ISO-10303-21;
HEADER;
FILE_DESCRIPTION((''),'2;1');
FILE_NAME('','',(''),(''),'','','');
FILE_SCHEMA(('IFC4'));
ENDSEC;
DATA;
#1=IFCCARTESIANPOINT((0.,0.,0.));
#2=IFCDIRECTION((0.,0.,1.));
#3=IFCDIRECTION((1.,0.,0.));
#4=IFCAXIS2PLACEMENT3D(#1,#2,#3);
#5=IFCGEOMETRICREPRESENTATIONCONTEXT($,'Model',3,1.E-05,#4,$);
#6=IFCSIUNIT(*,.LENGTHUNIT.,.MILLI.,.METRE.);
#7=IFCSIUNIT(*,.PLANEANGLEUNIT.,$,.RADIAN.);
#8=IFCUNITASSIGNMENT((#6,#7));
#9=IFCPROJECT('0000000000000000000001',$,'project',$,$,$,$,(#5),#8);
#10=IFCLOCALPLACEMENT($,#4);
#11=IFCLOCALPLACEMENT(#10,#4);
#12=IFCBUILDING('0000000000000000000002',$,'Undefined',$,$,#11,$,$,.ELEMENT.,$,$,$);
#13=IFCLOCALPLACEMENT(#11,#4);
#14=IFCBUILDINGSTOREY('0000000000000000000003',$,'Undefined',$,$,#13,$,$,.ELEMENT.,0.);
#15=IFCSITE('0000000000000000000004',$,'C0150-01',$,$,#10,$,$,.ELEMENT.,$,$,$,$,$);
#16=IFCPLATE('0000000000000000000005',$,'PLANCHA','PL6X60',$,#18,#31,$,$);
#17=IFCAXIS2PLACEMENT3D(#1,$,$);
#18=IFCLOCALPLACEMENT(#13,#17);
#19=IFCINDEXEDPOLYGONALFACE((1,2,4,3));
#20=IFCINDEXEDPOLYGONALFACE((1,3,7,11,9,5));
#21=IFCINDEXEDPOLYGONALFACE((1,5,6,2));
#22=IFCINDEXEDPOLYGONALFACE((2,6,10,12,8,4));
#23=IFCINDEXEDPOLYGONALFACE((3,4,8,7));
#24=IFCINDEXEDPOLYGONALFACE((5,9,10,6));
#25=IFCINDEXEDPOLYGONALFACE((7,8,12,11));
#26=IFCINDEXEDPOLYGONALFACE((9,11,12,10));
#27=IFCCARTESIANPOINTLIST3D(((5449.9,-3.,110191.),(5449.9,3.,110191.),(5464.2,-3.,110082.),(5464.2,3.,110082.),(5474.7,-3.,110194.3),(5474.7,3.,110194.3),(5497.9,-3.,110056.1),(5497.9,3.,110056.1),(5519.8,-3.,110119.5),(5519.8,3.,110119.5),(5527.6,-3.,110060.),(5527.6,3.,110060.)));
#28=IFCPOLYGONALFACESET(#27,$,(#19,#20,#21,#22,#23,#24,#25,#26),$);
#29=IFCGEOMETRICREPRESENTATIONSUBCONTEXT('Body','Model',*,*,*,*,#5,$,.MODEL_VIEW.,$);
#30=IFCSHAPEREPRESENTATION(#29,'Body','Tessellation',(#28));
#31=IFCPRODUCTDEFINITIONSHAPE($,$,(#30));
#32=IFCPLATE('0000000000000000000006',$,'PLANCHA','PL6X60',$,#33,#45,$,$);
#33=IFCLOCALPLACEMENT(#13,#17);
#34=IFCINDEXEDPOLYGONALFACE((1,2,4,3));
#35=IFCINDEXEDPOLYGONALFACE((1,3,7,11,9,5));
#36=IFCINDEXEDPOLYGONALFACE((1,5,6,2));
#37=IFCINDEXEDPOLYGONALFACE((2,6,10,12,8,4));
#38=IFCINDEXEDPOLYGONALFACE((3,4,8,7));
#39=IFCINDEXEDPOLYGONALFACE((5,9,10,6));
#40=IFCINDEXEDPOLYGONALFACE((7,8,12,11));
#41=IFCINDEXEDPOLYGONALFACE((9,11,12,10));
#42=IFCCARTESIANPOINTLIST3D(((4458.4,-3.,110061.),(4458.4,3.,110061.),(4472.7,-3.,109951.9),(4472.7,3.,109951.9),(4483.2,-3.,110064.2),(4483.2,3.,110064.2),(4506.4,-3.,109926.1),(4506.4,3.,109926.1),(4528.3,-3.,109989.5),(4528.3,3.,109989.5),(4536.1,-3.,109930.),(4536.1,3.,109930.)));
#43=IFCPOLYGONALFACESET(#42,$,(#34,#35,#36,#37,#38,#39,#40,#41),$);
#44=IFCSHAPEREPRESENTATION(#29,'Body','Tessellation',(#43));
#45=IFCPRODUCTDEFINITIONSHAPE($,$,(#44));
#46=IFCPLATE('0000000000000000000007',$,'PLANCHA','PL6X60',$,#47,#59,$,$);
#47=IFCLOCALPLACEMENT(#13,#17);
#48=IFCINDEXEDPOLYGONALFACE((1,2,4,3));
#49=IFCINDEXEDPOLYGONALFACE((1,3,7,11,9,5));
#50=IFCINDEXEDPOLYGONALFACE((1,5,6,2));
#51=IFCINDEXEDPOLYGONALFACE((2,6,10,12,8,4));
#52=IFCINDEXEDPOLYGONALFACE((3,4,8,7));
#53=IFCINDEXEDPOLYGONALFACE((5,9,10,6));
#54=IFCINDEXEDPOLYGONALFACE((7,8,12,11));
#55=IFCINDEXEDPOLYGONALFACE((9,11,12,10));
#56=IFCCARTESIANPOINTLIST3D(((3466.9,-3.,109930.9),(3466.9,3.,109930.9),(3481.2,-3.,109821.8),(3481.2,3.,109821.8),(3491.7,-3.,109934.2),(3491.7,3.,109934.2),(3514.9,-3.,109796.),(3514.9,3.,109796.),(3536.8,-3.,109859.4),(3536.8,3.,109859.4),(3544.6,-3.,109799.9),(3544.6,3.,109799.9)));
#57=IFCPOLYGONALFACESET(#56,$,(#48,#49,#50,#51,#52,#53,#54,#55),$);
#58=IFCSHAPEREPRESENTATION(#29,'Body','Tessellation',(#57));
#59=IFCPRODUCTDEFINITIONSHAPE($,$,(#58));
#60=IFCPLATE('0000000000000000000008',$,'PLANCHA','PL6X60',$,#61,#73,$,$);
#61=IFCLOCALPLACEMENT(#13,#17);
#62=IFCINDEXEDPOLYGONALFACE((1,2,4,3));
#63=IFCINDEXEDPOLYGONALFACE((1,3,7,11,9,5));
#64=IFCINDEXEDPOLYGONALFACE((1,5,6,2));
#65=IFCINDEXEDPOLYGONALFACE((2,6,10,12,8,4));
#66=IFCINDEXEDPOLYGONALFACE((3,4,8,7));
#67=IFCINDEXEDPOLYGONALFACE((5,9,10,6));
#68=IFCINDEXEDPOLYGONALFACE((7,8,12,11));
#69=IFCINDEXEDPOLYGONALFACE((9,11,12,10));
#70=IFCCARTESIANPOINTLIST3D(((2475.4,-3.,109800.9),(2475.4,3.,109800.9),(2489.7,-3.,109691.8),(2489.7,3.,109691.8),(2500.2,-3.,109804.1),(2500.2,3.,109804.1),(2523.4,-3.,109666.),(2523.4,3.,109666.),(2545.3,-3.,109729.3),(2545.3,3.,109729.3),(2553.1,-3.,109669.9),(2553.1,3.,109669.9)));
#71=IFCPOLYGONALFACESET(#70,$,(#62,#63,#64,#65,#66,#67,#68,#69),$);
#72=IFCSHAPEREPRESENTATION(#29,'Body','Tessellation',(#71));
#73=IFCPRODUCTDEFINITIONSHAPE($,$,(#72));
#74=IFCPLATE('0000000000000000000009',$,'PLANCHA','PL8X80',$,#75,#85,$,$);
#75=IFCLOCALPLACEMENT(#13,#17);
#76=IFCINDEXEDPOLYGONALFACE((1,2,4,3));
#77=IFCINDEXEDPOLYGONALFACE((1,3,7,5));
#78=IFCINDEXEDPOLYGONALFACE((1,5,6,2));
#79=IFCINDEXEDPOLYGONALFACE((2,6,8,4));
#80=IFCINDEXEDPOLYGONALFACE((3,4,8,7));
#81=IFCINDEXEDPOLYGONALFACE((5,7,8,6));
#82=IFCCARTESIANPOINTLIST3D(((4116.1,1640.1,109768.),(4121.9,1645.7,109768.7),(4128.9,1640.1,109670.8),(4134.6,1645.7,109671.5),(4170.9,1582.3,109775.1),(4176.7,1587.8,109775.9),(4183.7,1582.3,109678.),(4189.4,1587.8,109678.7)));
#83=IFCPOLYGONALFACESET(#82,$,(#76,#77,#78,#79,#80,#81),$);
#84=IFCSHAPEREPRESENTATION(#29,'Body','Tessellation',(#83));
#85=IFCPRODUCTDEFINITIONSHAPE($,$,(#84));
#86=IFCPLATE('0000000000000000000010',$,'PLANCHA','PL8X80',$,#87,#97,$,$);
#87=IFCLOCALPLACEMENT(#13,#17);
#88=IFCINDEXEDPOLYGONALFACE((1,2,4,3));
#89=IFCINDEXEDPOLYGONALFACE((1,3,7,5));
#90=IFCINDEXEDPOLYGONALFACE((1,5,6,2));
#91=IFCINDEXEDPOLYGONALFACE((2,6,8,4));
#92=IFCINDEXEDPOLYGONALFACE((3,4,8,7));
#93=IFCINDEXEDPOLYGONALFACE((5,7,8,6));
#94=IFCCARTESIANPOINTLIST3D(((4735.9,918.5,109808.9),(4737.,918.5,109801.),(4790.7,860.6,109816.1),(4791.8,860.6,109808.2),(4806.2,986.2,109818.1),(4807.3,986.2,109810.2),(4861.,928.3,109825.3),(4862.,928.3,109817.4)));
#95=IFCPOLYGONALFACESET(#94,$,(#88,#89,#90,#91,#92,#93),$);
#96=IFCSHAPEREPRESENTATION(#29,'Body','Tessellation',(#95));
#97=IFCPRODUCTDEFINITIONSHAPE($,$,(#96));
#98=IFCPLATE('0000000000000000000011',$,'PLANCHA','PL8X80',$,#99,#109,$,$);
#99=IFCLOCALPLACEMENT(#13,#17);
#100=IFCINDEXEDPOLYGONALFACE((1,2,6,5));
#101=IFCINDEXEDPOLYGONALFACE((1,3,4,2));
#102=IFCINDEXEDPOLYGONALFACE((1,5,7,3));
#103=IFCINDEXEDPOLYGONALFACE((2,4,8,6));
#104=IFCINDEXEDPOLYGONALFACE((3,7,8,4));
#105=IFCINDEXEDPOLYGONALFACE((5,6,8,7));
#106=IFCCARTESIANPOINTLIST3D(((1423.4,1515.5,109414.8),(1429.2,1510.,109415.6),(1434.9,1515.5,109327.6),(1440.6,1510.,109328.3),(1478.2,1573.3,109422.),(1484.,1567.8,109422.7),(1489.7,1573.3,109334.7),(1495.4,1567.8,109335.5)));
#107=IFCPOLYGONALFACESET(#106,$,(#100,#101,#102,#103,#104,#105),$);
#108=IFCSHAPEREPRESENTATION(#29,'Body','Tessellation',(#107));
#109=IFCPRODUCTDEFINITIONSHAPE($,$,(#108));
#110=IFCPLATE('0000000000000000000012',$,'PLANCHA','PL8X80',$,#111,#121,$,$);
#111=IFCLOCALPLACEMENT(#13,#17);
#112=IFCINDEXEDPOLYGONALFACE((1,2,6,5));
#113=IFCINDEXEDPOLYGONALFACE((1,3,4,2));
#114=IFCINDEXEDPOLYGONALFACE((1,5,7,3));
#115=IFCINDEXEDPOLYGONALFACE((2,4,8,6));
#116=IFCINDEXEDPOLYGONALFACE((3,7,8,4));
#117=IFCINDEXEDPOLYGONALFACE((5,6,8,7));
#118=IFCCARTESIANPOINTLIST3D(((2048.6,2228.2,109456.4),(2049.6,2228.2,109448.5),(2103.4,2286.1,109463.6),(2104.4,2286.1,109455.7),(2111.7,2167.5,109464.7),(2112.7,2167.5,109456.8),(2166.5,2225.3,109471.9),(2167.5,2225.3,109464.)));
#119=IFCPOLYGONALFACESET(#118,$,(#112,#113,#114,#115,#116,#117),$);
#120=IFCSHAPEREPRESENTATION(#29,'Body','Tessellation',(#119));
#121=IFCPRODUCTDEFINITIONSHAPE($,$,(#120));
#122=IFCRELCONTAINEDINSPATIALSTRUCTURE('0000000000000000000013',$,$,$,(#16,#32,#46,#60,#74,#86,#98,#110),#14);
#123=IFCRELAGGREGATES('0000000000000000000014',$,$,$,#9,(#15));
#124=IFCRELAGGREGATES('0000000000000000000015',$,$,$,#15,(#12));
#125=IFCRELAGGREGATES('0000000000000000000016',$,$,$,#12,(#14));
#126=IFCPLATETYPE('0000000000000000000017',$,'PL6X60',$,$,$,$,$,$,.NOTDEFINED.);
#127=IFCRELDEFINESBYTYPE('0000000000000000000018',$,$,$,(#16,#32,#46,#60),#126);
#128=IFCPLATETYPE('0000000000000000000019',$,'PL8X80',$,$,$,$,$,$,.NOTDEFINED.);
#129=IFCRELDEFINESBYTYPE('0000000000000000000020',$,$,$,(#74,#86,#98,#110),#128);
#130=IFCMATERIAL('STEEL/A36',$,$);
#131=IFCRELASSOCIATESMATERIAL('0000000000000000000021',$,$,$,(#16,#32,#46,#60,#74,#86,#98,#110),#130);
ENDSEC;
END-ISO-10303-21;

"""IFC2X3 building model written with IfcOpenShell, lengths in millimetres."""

from ifc_helpers import new_model, si_unit, frame, origin_with_axes, place, context, subcontext, project, spatial, polyline, outline, extrude, material, type_object, element, save


model = new_model("IFC2X3")

# Units and contexts
model_context = context("Model", 3, precision=1e-05, world=origin_with_axes())
body_context = subcontext(model_context, "Body", "Model", "MODEL_VIEW")
ifc_project = project(units=[si_unit("LENGTHUNIT", "METRE", prefix="MILLI"), si_unit("PLANEANGLEUNIT", "RADIAN")], contexts=[model_context])

# Site, building, storey
site_placement = place(None, origin_with_axes())
site = spatial("IfcSite", under=ifc_project, at=site_placement, Name="C0150-01", CompositionType="ELEMENT")
building_placement = place(site_placement, origin_with_axes())
building = spatial("IfcBuilding", under=site, at=building_placement, Name="Undefined", CompositionType="ELEMENT")
storey_placement = place(building_placement, origin_with_axes())
storey = spatial("IfcBuildingStorey", under=building, at=storey_placement, Name="Undefined", CompositionType="ELEMENT", Elevation=0.0)

# Shared definitions
ifc_material_1 = material(Name="STEEL/A36")

# Plates
plate_type_1 = type_object("IfcPlateType", Name="PL6X60", PredefinedType="NOTDEFINED")
for number, where, z_axis, x_axis, name in (
    (1, (5474.7, 0.0, 110194.3), (0.0, -1.0, 0.0), (-0.991507, 0.0, -0.130054), "PLANCHA"),
    (2, (4483.2, 0.0, 110064.2), (0.0, -1.0, 0.0), (-0.991507, 0.0, -0.130054), "PLANCHA"),
    (3, (3491.7, 0.0, 109934.2), (0.0, -1.0, 0.0), (-0.991507, 0.0, -0.130054), "PLANCHA"),
    (4, (2500.2, 0.0, 109804.1), (0.0, -1.0, 0.0), (-0.991507, 0.0, -0.130054), "PLANCHA"),
):
    element("IfcPlate", number, at=place(storey_placement, frame(where, z_axis=z_axis, x_axis=x_axis)), inside=storey, type_object=plate_type_1, material=ifc_material_1, Name=name, Description="PL6X60", context=body_context, shape_type="SweptSolid", body=[
        extrude(outline(polyline([(0.0, 0.0), (25.0, 0.0), (25.0, 110.0), (-5.0, 140.0), (-35.0, 140.0), (-35.0, 80.0), (0.0, 0.0)])), frame((0.0, 0.0, -3.0), z_axis=(0.0, 0.0, 1.0), x_axis=(1.0, 0.0, 0.0)), (0.0, 0.0, 1.0), 6.0),
    ])
plate_type_2 = type_object("IfcPlateType", Name="PL8X80", PredefinedType="NOTDEFINED")
for number, where, z_axis, x_axis, name in (
    (5, (4119.0, 1642.9, 109768.3), (-0.71713, -0.690563, -0.094065), (0.130054, 0.0, -0.991507), "PLANCHA"),
    (6, (4806.7, 986.2, 109814.2), (-0.130054, 0.0, 0.991507), (-0.71713, -0.690563, -0.094065), "PLANCHA"),
):
    element("IfcPlate", number, at=place(storey_placement, frame(where, z_axis=z_axis, x_axis=x_axis)), inside=storey, type_object=plate_type_2, material=ifc_material_1, Name=name, Description="PL8X80", context=body_context, shape_type="SweptSolid", body=[
        extrude(outline(polyline([(0.0, 0.0), (98.0, 0.0), (98.0, 80.0), (0.0, 80.0), (0.0, 0.0)])), frame((0.0, 0.0, -4.0), z_axis=(0.0, 0.0, 1.0), x_axis=(1.0, 0.0, 0.0)), (0.0, 0.0, 1.0), 8.0),
    ])
for number, where, z_axis, x_axis, name in (
    (7, (1492.5, 1570.6, 109335.1), (-0.71713, 0.690563, -0.094065), (-0.684698, -0.723272, -0.089811), "PLANCHA"),
    (8, (2103.9, 2286.1, 109459.6), (-0.130054, 0.0, 0.991507), (-0.684698, -0.723272, -0.089811), "PLANCHA"),
):
    element("IfcPlate", number, at=place(storey_placement, frame(where, z_axis=z_axis, x_axis=x_axis)), inside=storey, type_object=plate_type_2, material=ifc_material_1, Name=name, Description="PL8X80", context=body_context, shape_type="SweptSolid", body=[
        extrude(outline(polyline([(0.0, 0.0), (80.0, 0.0), (80.0, 88.0), (0.0, 88.0), (0.0, 0.0)])), frame((0.0, 0.0, -4.0), z_axis=(0.0, 0.0, 1.0), x_axis=(1.0, 0.0, 0.0)), (0.0, 0.0, 1.0), 8.0),
    ])

save(model, "model.ifc")
